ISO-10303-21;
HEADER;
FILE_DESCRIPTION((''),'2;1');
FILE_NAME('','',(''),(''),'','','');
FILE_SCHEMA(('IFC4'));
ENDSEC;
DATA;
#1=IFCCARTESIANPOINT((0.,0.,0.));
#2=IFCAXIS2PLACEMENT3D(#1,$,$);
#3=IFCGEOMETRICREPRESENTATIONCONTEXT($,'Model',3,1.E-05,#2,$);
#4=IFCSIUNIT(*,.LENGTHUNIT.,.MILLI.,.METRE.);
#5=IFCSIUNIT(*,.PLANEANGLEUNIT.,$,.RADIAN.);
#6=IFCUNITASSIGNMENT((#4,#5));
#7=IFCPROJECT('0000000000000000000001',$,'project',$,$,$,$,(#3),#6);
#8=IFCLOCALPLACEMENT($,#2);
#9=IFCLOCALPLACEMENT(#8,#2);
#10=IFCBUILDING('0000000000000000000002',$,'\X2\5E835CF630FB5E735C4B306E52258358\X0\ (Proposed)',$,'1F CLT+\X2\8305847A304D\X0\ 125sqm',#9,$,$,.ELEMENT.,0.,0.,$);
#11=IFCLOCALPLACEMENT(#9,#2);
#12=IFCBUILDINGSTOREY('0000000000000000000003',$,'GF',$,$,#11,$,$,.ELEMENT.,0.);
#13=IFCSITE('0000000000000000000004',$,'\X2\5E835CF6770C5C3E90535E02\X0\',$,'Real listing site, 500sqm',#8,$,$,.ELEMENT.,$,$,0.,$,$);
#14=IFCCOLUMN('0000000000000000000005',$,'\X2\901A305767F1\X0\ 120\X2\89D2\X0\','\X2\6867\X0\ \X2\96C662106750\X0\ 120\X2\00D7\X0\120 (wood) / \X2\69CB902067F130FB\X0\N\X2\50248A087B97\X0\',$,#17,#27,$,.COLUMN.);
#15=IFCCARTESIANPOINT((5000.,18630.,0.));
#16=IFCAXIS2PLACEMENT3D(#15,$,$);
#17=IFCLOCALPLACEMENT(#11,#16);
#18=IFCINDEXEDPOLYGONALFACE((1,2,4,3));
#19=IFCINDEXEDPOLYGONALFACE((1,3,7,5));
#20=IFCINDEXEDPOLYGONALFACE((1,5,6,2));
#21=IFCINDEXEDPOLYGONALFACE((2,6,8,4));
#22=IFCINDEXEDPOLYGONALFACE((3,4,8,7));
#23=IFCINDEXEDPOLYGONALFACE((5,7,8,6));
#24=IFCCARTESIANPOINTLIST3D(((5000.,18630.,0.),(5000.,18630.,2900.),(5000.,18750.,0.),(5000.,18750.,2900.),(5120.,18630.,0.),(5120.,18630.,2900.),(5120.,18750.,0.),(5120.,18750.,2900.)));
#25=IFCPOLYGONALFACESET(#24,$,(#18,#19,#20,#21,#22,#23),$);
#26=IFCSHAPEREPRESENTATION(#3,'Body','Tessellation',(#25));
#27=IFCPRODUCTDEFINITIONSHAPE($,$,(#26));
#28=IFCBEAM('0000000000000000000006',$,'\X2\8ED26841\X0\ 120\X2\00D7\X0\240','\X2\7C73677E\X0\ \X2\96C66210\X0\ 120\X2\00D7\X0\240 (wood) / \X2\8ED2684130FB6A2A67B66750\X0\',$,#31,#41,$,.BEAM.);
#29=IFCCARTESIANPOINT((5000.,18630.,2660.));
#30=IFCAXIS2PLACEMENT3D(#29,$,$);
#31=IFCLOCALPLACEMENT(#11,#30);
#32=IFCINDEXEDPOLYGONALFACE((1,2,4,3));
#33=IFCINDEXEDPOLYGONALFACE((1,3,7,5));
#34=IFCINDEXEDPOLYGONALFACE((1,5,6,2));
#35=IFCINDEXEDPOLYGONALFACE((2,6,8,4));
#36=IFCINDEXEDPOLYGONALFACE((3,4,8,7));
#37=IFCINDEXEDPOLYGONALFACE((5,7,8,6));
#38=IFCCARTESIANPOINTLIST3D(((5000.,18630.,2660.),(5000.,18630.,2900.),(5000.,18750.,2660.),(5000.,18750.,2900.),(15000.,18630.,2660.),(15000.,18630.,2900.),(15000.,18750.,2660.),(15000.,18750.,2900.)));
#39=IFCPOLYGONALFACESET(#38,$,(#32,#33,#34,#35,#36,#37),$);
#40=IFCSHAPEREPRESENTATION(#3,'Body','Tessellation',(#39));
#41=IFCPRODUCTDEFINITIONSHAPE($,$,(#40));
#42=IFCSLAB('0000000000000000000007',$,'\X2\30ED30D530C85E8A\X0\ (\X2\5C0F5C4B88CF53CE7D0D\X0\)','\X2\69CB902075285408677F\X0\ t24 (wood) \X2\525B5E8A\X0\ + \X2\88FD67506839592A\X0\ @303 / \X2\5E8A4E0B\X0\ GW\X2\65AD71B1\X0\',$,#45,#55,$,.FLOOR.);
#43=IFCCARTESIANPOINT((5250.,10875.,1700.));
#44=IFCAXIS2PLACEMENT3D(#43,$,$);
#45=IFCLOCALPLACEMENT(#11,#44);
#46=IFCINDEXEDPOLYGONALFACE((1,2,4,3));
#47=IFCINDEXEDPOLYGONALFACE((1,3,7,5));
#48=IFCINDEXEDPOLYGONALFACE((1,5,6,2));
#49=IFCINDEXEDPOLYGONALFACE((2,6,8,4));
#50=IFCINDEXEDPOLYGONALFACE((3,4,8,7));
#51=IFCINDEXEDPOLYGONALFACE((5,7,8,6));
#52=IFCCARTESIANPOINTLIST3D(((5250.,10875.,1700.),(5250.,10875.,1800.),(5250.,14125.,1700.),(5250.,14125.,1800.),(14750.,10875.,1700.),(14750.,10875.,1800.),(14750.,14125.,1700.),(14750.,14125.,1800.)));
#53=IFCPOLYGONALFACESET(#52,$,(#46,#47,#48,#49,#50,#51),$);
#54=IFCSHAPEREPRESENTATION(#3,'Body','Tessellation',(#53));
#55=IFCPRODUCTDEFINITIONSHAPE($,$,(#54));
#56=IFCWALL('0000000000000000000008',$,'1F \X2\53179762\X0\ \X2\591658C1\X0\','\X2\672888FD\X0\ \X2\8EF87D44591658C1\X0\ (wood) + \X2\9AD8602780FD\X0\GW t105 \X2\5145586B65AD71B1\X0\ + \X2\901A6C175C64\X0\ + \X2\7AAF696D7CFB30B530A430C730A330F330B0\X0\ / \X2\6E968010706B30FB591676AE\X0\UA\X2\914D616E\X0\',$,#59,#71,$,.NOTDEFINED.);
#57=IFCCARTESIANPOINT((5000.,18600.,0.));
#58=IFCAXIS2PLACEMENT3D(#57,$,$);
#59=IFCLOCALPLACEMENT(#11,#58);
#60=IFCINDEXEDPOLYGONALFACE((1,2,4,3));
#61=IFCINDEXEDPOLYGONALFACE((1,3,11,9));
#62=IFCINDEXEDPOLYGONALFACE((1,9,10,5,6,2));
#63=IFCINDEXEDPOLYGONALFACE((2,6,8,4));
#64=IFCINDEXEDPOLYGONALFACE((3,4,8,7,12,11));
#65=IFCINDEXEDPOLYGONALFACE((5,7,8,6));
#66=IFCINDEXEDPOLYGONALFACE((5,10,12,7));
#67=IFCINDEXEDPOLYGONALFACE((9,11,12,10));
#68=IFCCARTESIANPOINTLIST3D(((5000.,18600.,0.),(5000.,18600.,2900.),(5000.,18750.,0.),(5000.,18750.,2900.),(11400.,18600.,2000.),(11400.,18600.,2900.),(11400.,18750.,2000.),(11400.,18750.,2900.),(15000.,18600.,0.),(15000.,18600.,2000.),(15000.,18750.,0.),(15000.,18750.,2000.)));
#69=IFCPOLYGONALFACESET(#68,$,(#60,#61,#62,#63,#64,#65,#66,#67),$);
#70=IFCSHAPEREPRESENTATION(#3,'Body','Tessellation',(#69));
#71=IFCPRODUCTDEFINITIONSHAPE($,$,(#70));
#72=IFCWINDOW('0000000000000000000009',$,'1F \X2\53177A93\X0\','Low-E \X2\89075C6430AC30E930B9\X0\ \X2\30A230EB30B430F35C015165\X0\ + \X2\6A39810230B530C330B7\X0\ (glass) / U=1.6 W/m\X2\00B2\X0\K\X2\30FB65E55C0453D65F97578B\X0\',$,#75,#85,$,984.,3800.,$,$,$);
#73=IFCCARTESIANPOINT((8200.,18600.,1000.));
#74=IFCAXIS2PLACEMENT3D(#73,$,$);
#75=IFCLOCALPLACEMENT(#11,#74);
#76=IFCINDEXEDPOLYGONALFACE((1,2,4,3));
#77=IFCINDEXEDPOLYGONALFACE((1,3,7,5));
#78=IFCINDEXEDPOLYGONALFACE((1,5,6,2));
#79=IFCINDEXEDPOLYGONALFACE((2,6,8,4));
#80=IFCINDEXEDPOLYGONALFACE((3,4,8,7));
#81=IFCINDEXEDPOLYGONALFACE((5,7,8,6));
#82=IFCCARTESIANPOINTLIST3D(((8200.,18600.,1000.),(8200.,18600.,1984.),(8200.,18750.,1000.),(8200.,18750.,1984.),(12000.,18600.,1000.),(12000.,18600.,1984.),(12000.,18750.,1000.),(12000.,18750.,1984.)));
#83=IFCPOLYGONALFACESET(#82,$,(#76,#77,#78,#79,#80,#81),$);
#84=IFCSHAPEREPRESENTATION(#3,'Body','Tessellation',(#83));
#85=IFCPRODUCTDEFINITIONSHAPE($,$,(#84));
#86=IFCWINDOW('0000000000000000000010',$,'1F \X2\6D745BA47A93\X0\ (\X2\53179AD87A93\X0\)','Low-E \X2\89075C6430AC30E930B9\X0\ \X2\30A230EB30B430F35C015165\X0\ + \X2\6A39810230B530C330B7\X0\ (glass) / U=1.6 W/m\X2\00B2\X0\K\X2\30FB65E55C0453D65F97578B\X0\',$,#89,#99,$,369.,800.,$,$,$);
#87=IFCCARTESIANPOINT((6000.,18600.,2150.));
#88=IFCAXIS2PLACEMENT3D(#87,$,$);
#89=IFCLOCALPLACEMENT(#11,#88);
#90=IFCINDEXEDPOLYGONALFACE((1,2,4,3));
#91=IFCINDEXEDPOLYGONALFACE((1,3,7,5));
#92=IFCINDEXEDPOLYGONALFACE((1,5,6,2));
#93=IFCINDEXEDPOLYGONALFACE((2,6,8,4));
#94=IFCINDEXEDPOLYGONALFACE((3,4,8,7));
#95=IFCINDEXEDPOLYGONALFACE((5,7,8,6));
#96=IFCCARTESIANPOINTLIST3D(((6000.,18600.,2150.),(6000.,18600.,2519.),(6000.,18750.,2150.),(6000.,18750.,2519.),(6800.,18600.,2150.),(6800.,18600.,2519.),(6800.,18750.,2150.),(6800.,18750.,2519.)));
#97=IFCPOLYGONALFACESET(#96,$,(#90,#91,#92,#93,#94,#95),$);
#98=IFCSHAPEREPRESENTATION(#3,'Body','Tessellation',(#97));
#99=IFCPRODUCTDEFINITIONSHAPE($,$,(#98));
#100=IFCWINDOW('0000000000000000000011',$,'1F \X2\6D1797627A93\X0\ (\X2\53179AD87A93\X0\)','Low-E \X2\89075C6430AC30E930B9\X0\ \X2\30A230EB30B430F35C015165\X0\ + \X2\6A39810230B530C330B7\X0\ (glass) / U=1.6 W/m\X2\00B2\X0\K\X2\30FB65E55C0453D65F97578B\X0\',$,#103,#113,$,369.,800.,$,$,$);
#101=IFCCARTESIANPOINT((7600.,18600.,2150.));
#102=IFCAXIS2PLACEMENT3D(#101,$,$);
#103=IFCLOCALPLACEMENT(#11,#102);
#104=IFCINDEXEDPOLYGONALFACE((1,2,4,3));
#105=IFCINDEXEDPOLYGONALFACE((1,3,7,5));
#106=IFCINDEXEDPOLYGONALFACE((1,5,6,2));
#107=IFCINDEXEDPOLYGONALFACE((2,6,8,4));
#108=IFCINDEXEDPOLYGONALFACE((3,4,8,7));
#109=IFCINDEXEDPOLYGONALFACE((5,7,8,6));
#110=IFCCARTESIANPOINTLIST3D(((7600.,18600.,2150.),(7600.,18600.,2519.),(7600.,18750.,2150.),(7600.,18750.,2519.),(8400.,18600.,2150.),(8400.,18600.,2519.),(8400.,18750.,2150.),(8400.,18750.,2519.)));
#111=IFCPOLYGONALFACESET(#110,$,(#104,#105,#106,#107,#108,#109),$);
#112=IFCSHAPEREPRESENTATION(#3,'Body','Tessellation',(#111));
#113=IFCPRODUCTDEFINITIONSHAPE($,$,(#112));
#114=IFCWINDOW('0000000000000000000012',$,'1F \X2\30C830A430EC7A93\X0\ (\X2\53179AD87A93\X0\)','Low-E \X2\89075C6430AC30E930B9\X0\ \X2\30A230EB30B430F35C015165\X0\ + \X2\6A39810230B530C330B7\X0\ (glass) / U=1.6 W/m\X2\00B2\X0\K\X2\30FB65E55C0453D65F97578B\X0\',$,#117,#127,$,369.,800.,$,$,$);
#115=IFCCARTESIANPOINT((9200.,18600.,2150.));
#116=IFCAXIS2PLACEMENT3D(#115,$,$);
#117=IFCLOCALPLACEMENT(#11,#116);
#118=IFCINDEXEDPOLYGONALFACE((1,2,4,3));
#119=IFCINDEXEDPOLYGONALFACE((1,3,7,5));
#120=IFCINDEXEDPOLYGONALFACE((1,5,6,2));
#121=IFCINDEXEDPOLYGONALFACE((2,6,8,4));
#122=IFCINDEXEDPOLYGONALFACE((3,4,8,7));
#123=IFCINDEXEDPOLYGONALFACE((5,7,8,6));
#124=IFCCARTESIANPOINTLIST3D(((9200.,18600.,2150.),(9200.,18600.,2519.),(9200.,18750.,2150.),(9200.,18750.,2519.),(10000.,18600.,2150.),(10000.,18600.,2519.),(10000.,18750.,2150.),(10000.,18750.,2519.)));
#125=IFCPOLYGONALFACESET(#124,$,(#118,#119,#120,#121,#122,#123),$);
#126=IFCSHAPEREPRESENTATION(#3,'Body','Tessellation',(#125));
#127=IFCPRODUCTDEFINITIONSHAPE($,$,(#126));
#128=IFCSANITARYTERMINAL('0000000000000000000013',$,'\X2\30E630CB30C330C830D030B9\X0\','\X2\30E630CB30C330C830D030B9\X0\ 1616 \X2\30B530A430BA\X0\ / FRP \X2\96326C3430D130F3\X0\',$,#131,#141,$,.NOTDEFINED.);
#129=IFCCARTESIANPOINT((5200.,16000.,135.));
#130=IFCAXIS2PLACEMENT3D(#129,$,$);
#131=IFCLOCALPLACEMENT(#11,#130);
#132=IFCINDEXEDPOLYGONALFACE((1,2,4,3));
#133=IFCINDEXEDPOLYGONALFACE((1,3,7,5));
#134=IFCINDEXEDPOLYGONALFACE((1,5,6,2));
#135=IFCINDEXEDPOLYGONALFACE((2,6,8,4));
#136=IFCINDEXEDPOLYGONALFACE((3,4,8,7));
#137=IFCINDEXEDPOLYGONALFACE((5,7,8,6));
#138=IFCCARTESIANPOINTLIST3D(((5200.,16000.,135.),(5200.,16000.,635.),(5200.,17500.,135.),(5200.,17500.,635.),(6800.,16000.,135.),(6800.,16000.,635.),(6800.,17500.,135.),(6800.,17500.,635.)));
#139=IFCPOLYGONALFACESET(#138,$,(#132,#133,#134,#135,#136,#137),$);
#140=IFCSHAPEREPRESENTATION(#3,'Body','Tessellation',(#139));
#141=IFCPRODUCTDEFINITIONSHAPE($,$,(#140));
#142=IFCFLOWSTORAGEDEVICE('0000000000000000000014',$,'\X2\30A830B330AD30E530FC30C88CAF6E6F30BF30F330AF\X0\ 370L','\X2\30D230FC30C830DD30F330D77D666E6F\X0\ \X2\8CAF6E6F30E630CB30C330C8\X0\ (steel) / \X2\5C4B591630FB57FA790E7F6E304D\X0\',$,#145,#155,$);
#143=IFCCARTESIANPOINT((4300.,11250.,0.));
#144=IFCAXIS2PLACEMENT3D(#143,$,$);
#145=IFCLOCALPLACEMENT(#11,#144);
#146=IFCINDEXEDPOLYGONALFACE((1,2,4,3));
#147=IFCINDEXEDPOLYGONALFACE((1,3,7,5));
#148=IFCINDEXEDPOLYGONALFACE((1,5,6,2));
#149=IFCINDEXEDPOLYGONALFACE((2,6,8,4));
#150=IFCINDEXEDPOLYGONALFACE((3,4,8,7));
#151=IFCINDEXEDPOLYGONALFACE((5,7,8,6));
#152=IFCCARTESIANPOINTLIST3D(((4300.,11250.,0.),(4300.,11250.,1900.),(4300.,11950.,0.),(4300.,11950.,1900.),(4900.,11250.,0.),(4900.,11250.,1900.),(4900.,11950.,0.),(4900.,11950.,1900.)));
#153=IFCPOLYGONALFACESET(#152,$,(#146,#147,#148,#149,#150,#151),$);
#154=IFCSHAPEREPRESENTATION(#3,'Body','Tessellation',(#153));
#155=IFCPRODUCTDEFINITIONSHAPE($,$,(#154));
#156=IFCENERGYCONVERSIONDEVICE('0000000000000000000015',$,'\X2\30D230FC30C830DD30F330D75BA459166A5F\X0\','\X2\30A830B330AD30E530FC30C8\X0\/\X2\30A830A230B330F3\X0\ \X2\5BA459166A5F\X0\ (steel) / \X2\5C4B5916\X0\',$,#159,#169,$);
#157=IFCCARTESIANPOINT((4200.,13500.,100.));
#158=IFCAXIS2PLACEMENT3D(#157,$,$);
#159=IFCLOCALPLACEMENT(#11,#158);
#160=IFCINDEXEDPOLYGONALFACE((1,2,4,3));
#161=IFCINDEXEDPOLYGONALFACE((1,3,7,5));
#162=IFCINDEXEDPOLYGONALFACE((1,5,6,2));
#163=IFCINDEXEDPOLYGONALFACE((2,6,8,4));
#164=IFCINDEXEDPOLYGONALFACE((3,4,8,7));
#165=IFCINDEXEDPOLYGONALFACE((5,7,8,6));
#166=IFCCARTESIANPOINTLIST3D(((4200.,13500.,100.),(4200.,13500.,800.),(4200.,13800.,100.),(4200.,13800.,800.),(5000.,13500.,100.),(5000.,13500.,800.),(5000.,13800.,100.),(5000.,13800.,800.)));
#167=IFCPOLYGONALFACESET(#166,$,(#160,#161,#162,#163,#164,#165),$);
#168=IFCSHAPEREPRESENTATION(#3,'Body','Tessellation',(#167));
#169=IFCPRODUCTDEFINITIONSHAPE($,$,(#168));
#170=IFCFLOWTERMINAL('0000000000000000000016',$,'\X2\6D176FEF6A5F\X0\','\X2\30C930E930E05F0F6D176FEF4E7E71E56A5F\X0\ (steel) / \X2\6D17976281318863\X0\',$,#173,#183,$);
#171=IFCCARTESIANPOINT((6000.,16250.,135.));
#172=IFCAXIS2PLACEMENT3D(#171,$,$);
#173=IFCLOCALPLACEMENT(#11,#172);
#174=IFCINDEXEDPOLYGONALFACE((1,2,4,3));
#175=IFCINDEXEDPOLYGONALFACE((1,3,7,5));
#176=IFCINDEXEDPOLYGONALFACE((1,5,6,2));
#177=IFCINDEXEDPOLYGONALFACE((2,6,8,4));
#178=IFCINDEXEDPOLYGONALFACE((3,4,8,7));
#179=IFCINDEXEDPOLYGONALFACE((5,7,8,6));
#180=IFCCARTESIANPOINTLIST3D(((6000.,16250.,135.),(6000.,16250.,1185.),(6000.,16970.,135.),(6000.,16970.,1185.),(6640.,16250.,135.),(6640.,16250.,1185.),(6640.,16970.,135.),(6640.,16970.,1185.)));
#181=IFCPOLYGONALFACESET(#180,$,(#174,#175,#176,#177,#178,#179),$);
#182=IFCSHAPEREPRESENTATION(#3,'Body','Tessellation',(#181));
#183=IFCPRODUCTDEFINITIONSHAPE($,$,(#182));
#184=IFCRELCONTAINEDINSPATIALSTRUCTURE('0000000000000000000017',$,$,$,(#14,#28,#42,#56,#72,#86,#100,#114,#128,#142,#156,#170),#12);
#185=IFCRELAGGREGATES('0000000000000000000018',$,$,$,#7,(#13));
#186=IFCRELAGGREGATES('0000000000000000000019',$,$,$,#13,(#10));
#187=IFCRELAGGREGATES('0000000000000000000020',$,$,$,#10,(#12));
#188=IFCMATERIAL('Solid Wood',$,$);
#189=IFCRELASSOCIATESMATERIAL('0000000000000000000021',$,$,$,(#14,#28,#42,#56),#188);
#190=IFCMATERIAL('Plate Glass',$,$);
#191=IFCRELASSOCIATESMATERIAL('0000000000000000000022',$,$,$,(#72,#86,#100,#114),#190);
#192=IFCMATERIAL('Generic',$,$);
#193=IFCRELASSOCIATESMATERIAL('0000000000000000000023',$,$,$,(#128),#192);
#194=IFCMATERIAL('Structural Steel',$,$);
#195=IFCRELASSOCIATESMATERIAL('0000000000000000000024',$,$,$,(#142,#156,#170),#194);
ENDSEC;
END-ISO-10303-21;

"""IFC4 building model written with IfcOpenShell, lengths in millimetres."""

from ifc_helpers import new_model, si_unit, frame, frame_2d, origin, place, context, project, spatial, rectangle, extrude, material, element, fill, save


model = new_model("IFC4")

# Units and contexts
model_context = context("Model", 3, precision=1e-05, world=origin())
ifc_project = project(units=[si_unit("LENGTHUNIT", "METRE", prefix="MILLI"), si_unit("PLANEANGLEUNIT", "RADIAN")], contexts=[model_context])

# Site, building, storey
site_placement = place(None, origin())
site = spatial("IfcSite", under=ifc_project, at=site_placement, Name="広島県尾道市", ObjectType="Real listing site, 500sqm", CompositionType="ELEMENT", RefElevation=0.0)
building_placement = place(site_placement, origin())
building = spatial("IfcBuilding", under=site, at=building_placement, Name="広島・平屋の別荘 (Proposed)", ObjectType="1F CLT+茅葺き 125sqm", CompositionType="ELEMENT", ElevationOfRefHeight=0.0, ElevationOfTerrain=0.0)
storey_placement = place(building_placement, origin())
storey = spatial("IfcBuildingStorey", under=building, at=storey_placement, Name="GF", CompositionType="ELEMENT", Elevation=0.0)

# Column
ifc_material_1 = material(Name="Solid Wood")
column_1_placement = place(storey_placement, frame((5000.0, 18630.0, 0.0)))
element("IfcColumn", 1, at=column_1_placement, inside=storey, material=ifc_material_1, Name="通し柱 120角", Description="桧 集成材 120×120 (wood) / 構造柱・N値計算", PredefinedType="COLUMN", context=model_context, shape_type="SweptSolid", body=[
    extrude(rectangle(XDim=120.0, YDim=120.0, at=frame_2d((60.0, 60.0))), frame((5000.0, 18630.0, 0.0)), (0.0, 0.0, 1.0), 2900.0),
])

# Beam
beam_1_placement = place(storey_placement, frame((5000.0, 18630.0, 2660.0)))
element("IfcBeam", 2, at=beam_1_placement, inside=storey, material=ifc_material_1, Name="軒桁 120×240", Description="米松 集成 120×240 (wood) / 軒桁・横架材", PredefinedType="BEAM", context=model_context, shape_type="SweptSolid", body=[
    extrude(rectangle(XDim=10000.0, YDim=120.0, at=frame_2d((5000.0, 60.0))), frame((5000.0, 18630.0, 2660.0)), (0.0, 0.0, 1.0), 240.0),
])

# Slab
slab_placement = place(storey_placement, frame((5250.0, 10875.0, 1700.0)))
element("IfcSlab", 3, at=slab_placement, inside=storey, material=ifc_material_1, Name="ロフト床 (小屋裏収納)", Description="構造用合板 t24 (wood) 剛床 + 製材根太 @303 / 床下 GW断熱", PredefinedType="FLOOR", context=model_context, shape_type="SweptSolid", body=[
    extrude(rectangle(XDim=9500.0, YDim=3250.0, at=frame_2d((4750.0, 1625.0))), frame((5250.0, 10875.0, 1700.0)), (0.0, 0.0, 1.0), 100.0),
])

# Wall, openings, windows
wall_1_placement = place(storey_placement, frame((5000.0, 18600.0, 0.0)))
wall_1 = element("IfcWall", 4, at=wall_1_placement, inside=storey, material=ifc_material_1, Name="1F 北面 外壁", Description="木製 軸組外壁 (wood) + 高性能GW t105 充填断熱 + 通気層 + 窯業系サイディング / 準耐火・外皮UA配慮", PredefinedType="NOTDEFINED", context=model_context, shape_type="SweptSolid", body=[
    extrude(rectangle(XDim=10000.0, YDim=150.0, at=frame_2d((5000.0, 75.0))), frame((5000.0, 18600.0, 0.0)), (0.0, 0.0, 1.0), 2900.0),
])
opening_1_placement = place(storey_placement, frame((8200.0, 18600.0, 1000.0)))
opening_1 = element("IfcOpeningElement", 5, at=opening_1_placement, cuts=wall_1, PredefinedType="NOTDEFINED", context=model_context, shape_type="SweptSolid", body=[
    extrude(rectangle(XDim=3800.0, YDim=150.0, at=frame_2d((1900.0, 75.0))), frame((8200.0, 18600.0, 1000.0)), (0.0, 0.0, 1.0), 984.0),
])
opening_2_placement = place(storey_placement, frame((6000.0, 18600.0, 2150.0)))
opening_2 = element("IfcOpeningElement", 6, at=opening_2_placement, cuts=wall_1, PredefinedType="NOTDEFINED", context=model_context, shape_type="SweptSolid", body=[
    extrude(rectangle(XDim=800.0, YDim=150.0, at=frame_2d((400.0, 75.0))), frame((6000.0, 18600.0, 2150.0)), (0.0, 0.0, 1.0), 369.0),
])
opening_3_placement = place(storey_placement, frame((7600.0, 18600.0, 2150.0)))
opening_3 = element("IfcOpeningElement", 7, at=opening_3_placement, cuts=wall_1, PredefinedType="NOTDEFINED", context=model_context, shape_type="SweptSolid", body=[
    extrude(rectangle(XDim=800.0, YDim=150.0, at=frame_2d((400.0, 75.0))), frame((7600.0, 18600.0, 2150.0)), (0.0, 0.0, 1.0), 369.0),
])
opening_4_placement = place(storey_placement, frame((9200.0, 18600.0, 2150.0)))
opening_4 = element("IfcOpeningElement", 8, at=opening_4_placement, cuts=wall_1, PredefinedType="NOTDEFINED", context=model_context, shape_type="SweptSolid", body=[
    extrude(rectangle(XDim=800.0, YDim=150.0, at=frame_2d((400.0, 75.0))), frame((9200.0, 18600.0, 2150.0)), (0.0, 0.0, 1.0), 369.0),
])
ifc_material_2 = material(Name="Plate Glass")
window_1_placement = place(storey_placement, frame((8200.0, 18600.0, 1000.0)))
window_1 = element("IfcWindow", 9, at=window_1_placement, inside=storey, material=ifc_material_2, Name="1F 北窓", Description="Low-E 複層ガラス アルゴン封入 + 樹脂サッシ (glass) / U=1.6 W/m²K・日射取得型", OverallHeight=984.0, OverallWidth=3800.0, context=model_context, shape_type="SweptSolid", body=[
    extrude(rectangle(XDim=3800.0, YDim=150.0, at=frame_2d((1900.0, 75.0))), frame((8200.0, 18600.0, 1000.0)), (0.0, 0.0, 1.0), 984.0),
])
fill(opening_1, window_1)
window_2_placement = place(storey_placement, frame((6000.0, 18600.0, 2150.0)))
window_2 = element("IfcWindow", 10, at=window_2_placement, inside=storey, material=ifc_material_2, Name="1F 浴室窓 (北高窓)", Description="Low-E 複層ガラス アルゴン封入 + 樹脂サッシ (glass) / U=1.6 W/m²K・日射取得型", OverallHeight=369.0, OverallWidth=800.0, context=model_context, shape_type="SweptSolid", body=[
    extrude(rectangle(XDim=800.0, YDim=150.0, at=frame_2d((400.0, 75.0))), frame((6000.0, 18600.0, 2150.0)), (0.0, 0.0, 1.0), 369.0),
])
fill(opening_2, window_2)
window_3_placement = place(storey_placement, frame((7600.0, 18600.0, 2150.0)))
window_3 = element("IfcWindow", 11, at=window_3_placement, inside=storey, material=ifc_material_2, Name="1F 洗面窓 (北高窓)", Description="Low-E 複層ガラス アルゴン封入 + 樹脂サッシ (glass) / U=1.6 W/m²K・日射取得型", OverallHeight=369.0, OverallWidth=800.0, context=model_context, shape_type="SweptSolid", body=[
    extrude(rectangle(XDim=800.0, YDim=150.0, at=frame_2d((400.0, 75.0))), frame((7600.0, 18600.0, 2150.0)), (0.0, 0.0, 1.0), 369.0),
])
fill(opening_3, window_3)
window_4_placement = place(storey_placement, frame((9200.0, 18600.0, 2150.0)))
window_4 = element("IfcWindow", 12, at=window_4_placement, inside=storey, material=ifc_material_2, Name="1F トイレ窓 (北高窓)", Description="Low-E 複層ガラス アルゴン封入 + 樹脂サッシ (glass) / U=1.6 W/m²K・日射取得型", OverallHeight=369.0, OverallWidth=800.0, context=model_context, shape_type="SweptSolid", body=[
    extrude(rectangle(XDim=800.0, YDim=150.0, at=frame_2d((400.0, 75.0))), frame((9200.0, 18600.0, 2150.0)), (0.0, 0.0, 1.0), 369.0),
])
fill(opening_4, window_4)

# Sanitary terminal
ifc_material_3 = material(Name="Generic")
sanitary_terminal_placement = place(storey_placement, frame((5200.0, 16000.0, 135.0)))
element("IfcSanitaryTerminal", 13, at=sanitary_terminal_placement, inside=storey, material=ifc_material_3, Name="ユニットバス", Description="ユニットバス 1616 サイズ / FRP 防水パン", PredefinedType="NOTDEFINED", context=model_context, shape_type="SweptSolid", body=[
    extrude(rectangle(XDim=1600.0, YDim=1500.0, at=frame_2d((800.0, 750.0))), frame((5200.0, 16000.0, 135.0)), (0.0, 0.0, 1.0), 500.0),
])

# Flow storage device
ifc_material_4 = material(Name="Structural Steel")
flow_storage_device_placement = place(storey_placement, frame((4300.0, 11250.0, 0.0)))
element("IfcFlowStorageDevice", 14, at=flow_storage_device_placement, inside=storey, material=ifc_material_4, Name="エコキュート貯湯タンク 370L", Description="ヒートポンプ給湯 貯湯ユニット (steel) / 屋外・基礎置き", context=model_context, shape_type="SweptSolid", body=[
    extrude(rectangle(XDim=600.0, YDim=700.0, at=frame_2d((300.0, 350.0))), frame((4300.0, 11250.0, 0.0)), (0.0, 0.0, 1.0), 1900.0),
])

# Energy conversion device
energy_conversion_device_placement = place(storey_placement, frame((4200.0, 13500.0, 100.0)))
element("IfcEnergyConversionDevice", 15, at=energy_conversion_device_placement, inside=storey, material=ifc_material_4, Name="ヒートポンプ室外機", Description="エコキュート/エアコン 室外機 (steel) / 屋外", context=model_context, shape_type="SweptSolid", body=[
    extrude(rectangle(XDim=800.0, YDim=300.0, at=frame_2d((400.0, 150.0))), frame((4200.0, 13500.0, 100.0)), (0.0, 0.0, 1.0), 700.0),
])

# Flow terminal
flow_terminal_placement = place(storey_placement, frame((6000.0, 16250.0, 135.0)))
element("IfcFlowTerminal", 16, at=flow_terminal_placement, inside=storey, material=ifc_material_4, Name="洗濯機", Description="ドラム式洗濯乾燥機 (steel) / 洗面脱衣", context=model_context, shape_type="SweptSolid", body=[
    extrude(rectangle(XDim=640.0, YDim=720.0, at=frame_2d((320.0, 360.0))), frame((6000.0, 16250.0, 135.0)), (0.0, 0.0, 1.0), 1050.0),
])

save(model, "model.ifc")
